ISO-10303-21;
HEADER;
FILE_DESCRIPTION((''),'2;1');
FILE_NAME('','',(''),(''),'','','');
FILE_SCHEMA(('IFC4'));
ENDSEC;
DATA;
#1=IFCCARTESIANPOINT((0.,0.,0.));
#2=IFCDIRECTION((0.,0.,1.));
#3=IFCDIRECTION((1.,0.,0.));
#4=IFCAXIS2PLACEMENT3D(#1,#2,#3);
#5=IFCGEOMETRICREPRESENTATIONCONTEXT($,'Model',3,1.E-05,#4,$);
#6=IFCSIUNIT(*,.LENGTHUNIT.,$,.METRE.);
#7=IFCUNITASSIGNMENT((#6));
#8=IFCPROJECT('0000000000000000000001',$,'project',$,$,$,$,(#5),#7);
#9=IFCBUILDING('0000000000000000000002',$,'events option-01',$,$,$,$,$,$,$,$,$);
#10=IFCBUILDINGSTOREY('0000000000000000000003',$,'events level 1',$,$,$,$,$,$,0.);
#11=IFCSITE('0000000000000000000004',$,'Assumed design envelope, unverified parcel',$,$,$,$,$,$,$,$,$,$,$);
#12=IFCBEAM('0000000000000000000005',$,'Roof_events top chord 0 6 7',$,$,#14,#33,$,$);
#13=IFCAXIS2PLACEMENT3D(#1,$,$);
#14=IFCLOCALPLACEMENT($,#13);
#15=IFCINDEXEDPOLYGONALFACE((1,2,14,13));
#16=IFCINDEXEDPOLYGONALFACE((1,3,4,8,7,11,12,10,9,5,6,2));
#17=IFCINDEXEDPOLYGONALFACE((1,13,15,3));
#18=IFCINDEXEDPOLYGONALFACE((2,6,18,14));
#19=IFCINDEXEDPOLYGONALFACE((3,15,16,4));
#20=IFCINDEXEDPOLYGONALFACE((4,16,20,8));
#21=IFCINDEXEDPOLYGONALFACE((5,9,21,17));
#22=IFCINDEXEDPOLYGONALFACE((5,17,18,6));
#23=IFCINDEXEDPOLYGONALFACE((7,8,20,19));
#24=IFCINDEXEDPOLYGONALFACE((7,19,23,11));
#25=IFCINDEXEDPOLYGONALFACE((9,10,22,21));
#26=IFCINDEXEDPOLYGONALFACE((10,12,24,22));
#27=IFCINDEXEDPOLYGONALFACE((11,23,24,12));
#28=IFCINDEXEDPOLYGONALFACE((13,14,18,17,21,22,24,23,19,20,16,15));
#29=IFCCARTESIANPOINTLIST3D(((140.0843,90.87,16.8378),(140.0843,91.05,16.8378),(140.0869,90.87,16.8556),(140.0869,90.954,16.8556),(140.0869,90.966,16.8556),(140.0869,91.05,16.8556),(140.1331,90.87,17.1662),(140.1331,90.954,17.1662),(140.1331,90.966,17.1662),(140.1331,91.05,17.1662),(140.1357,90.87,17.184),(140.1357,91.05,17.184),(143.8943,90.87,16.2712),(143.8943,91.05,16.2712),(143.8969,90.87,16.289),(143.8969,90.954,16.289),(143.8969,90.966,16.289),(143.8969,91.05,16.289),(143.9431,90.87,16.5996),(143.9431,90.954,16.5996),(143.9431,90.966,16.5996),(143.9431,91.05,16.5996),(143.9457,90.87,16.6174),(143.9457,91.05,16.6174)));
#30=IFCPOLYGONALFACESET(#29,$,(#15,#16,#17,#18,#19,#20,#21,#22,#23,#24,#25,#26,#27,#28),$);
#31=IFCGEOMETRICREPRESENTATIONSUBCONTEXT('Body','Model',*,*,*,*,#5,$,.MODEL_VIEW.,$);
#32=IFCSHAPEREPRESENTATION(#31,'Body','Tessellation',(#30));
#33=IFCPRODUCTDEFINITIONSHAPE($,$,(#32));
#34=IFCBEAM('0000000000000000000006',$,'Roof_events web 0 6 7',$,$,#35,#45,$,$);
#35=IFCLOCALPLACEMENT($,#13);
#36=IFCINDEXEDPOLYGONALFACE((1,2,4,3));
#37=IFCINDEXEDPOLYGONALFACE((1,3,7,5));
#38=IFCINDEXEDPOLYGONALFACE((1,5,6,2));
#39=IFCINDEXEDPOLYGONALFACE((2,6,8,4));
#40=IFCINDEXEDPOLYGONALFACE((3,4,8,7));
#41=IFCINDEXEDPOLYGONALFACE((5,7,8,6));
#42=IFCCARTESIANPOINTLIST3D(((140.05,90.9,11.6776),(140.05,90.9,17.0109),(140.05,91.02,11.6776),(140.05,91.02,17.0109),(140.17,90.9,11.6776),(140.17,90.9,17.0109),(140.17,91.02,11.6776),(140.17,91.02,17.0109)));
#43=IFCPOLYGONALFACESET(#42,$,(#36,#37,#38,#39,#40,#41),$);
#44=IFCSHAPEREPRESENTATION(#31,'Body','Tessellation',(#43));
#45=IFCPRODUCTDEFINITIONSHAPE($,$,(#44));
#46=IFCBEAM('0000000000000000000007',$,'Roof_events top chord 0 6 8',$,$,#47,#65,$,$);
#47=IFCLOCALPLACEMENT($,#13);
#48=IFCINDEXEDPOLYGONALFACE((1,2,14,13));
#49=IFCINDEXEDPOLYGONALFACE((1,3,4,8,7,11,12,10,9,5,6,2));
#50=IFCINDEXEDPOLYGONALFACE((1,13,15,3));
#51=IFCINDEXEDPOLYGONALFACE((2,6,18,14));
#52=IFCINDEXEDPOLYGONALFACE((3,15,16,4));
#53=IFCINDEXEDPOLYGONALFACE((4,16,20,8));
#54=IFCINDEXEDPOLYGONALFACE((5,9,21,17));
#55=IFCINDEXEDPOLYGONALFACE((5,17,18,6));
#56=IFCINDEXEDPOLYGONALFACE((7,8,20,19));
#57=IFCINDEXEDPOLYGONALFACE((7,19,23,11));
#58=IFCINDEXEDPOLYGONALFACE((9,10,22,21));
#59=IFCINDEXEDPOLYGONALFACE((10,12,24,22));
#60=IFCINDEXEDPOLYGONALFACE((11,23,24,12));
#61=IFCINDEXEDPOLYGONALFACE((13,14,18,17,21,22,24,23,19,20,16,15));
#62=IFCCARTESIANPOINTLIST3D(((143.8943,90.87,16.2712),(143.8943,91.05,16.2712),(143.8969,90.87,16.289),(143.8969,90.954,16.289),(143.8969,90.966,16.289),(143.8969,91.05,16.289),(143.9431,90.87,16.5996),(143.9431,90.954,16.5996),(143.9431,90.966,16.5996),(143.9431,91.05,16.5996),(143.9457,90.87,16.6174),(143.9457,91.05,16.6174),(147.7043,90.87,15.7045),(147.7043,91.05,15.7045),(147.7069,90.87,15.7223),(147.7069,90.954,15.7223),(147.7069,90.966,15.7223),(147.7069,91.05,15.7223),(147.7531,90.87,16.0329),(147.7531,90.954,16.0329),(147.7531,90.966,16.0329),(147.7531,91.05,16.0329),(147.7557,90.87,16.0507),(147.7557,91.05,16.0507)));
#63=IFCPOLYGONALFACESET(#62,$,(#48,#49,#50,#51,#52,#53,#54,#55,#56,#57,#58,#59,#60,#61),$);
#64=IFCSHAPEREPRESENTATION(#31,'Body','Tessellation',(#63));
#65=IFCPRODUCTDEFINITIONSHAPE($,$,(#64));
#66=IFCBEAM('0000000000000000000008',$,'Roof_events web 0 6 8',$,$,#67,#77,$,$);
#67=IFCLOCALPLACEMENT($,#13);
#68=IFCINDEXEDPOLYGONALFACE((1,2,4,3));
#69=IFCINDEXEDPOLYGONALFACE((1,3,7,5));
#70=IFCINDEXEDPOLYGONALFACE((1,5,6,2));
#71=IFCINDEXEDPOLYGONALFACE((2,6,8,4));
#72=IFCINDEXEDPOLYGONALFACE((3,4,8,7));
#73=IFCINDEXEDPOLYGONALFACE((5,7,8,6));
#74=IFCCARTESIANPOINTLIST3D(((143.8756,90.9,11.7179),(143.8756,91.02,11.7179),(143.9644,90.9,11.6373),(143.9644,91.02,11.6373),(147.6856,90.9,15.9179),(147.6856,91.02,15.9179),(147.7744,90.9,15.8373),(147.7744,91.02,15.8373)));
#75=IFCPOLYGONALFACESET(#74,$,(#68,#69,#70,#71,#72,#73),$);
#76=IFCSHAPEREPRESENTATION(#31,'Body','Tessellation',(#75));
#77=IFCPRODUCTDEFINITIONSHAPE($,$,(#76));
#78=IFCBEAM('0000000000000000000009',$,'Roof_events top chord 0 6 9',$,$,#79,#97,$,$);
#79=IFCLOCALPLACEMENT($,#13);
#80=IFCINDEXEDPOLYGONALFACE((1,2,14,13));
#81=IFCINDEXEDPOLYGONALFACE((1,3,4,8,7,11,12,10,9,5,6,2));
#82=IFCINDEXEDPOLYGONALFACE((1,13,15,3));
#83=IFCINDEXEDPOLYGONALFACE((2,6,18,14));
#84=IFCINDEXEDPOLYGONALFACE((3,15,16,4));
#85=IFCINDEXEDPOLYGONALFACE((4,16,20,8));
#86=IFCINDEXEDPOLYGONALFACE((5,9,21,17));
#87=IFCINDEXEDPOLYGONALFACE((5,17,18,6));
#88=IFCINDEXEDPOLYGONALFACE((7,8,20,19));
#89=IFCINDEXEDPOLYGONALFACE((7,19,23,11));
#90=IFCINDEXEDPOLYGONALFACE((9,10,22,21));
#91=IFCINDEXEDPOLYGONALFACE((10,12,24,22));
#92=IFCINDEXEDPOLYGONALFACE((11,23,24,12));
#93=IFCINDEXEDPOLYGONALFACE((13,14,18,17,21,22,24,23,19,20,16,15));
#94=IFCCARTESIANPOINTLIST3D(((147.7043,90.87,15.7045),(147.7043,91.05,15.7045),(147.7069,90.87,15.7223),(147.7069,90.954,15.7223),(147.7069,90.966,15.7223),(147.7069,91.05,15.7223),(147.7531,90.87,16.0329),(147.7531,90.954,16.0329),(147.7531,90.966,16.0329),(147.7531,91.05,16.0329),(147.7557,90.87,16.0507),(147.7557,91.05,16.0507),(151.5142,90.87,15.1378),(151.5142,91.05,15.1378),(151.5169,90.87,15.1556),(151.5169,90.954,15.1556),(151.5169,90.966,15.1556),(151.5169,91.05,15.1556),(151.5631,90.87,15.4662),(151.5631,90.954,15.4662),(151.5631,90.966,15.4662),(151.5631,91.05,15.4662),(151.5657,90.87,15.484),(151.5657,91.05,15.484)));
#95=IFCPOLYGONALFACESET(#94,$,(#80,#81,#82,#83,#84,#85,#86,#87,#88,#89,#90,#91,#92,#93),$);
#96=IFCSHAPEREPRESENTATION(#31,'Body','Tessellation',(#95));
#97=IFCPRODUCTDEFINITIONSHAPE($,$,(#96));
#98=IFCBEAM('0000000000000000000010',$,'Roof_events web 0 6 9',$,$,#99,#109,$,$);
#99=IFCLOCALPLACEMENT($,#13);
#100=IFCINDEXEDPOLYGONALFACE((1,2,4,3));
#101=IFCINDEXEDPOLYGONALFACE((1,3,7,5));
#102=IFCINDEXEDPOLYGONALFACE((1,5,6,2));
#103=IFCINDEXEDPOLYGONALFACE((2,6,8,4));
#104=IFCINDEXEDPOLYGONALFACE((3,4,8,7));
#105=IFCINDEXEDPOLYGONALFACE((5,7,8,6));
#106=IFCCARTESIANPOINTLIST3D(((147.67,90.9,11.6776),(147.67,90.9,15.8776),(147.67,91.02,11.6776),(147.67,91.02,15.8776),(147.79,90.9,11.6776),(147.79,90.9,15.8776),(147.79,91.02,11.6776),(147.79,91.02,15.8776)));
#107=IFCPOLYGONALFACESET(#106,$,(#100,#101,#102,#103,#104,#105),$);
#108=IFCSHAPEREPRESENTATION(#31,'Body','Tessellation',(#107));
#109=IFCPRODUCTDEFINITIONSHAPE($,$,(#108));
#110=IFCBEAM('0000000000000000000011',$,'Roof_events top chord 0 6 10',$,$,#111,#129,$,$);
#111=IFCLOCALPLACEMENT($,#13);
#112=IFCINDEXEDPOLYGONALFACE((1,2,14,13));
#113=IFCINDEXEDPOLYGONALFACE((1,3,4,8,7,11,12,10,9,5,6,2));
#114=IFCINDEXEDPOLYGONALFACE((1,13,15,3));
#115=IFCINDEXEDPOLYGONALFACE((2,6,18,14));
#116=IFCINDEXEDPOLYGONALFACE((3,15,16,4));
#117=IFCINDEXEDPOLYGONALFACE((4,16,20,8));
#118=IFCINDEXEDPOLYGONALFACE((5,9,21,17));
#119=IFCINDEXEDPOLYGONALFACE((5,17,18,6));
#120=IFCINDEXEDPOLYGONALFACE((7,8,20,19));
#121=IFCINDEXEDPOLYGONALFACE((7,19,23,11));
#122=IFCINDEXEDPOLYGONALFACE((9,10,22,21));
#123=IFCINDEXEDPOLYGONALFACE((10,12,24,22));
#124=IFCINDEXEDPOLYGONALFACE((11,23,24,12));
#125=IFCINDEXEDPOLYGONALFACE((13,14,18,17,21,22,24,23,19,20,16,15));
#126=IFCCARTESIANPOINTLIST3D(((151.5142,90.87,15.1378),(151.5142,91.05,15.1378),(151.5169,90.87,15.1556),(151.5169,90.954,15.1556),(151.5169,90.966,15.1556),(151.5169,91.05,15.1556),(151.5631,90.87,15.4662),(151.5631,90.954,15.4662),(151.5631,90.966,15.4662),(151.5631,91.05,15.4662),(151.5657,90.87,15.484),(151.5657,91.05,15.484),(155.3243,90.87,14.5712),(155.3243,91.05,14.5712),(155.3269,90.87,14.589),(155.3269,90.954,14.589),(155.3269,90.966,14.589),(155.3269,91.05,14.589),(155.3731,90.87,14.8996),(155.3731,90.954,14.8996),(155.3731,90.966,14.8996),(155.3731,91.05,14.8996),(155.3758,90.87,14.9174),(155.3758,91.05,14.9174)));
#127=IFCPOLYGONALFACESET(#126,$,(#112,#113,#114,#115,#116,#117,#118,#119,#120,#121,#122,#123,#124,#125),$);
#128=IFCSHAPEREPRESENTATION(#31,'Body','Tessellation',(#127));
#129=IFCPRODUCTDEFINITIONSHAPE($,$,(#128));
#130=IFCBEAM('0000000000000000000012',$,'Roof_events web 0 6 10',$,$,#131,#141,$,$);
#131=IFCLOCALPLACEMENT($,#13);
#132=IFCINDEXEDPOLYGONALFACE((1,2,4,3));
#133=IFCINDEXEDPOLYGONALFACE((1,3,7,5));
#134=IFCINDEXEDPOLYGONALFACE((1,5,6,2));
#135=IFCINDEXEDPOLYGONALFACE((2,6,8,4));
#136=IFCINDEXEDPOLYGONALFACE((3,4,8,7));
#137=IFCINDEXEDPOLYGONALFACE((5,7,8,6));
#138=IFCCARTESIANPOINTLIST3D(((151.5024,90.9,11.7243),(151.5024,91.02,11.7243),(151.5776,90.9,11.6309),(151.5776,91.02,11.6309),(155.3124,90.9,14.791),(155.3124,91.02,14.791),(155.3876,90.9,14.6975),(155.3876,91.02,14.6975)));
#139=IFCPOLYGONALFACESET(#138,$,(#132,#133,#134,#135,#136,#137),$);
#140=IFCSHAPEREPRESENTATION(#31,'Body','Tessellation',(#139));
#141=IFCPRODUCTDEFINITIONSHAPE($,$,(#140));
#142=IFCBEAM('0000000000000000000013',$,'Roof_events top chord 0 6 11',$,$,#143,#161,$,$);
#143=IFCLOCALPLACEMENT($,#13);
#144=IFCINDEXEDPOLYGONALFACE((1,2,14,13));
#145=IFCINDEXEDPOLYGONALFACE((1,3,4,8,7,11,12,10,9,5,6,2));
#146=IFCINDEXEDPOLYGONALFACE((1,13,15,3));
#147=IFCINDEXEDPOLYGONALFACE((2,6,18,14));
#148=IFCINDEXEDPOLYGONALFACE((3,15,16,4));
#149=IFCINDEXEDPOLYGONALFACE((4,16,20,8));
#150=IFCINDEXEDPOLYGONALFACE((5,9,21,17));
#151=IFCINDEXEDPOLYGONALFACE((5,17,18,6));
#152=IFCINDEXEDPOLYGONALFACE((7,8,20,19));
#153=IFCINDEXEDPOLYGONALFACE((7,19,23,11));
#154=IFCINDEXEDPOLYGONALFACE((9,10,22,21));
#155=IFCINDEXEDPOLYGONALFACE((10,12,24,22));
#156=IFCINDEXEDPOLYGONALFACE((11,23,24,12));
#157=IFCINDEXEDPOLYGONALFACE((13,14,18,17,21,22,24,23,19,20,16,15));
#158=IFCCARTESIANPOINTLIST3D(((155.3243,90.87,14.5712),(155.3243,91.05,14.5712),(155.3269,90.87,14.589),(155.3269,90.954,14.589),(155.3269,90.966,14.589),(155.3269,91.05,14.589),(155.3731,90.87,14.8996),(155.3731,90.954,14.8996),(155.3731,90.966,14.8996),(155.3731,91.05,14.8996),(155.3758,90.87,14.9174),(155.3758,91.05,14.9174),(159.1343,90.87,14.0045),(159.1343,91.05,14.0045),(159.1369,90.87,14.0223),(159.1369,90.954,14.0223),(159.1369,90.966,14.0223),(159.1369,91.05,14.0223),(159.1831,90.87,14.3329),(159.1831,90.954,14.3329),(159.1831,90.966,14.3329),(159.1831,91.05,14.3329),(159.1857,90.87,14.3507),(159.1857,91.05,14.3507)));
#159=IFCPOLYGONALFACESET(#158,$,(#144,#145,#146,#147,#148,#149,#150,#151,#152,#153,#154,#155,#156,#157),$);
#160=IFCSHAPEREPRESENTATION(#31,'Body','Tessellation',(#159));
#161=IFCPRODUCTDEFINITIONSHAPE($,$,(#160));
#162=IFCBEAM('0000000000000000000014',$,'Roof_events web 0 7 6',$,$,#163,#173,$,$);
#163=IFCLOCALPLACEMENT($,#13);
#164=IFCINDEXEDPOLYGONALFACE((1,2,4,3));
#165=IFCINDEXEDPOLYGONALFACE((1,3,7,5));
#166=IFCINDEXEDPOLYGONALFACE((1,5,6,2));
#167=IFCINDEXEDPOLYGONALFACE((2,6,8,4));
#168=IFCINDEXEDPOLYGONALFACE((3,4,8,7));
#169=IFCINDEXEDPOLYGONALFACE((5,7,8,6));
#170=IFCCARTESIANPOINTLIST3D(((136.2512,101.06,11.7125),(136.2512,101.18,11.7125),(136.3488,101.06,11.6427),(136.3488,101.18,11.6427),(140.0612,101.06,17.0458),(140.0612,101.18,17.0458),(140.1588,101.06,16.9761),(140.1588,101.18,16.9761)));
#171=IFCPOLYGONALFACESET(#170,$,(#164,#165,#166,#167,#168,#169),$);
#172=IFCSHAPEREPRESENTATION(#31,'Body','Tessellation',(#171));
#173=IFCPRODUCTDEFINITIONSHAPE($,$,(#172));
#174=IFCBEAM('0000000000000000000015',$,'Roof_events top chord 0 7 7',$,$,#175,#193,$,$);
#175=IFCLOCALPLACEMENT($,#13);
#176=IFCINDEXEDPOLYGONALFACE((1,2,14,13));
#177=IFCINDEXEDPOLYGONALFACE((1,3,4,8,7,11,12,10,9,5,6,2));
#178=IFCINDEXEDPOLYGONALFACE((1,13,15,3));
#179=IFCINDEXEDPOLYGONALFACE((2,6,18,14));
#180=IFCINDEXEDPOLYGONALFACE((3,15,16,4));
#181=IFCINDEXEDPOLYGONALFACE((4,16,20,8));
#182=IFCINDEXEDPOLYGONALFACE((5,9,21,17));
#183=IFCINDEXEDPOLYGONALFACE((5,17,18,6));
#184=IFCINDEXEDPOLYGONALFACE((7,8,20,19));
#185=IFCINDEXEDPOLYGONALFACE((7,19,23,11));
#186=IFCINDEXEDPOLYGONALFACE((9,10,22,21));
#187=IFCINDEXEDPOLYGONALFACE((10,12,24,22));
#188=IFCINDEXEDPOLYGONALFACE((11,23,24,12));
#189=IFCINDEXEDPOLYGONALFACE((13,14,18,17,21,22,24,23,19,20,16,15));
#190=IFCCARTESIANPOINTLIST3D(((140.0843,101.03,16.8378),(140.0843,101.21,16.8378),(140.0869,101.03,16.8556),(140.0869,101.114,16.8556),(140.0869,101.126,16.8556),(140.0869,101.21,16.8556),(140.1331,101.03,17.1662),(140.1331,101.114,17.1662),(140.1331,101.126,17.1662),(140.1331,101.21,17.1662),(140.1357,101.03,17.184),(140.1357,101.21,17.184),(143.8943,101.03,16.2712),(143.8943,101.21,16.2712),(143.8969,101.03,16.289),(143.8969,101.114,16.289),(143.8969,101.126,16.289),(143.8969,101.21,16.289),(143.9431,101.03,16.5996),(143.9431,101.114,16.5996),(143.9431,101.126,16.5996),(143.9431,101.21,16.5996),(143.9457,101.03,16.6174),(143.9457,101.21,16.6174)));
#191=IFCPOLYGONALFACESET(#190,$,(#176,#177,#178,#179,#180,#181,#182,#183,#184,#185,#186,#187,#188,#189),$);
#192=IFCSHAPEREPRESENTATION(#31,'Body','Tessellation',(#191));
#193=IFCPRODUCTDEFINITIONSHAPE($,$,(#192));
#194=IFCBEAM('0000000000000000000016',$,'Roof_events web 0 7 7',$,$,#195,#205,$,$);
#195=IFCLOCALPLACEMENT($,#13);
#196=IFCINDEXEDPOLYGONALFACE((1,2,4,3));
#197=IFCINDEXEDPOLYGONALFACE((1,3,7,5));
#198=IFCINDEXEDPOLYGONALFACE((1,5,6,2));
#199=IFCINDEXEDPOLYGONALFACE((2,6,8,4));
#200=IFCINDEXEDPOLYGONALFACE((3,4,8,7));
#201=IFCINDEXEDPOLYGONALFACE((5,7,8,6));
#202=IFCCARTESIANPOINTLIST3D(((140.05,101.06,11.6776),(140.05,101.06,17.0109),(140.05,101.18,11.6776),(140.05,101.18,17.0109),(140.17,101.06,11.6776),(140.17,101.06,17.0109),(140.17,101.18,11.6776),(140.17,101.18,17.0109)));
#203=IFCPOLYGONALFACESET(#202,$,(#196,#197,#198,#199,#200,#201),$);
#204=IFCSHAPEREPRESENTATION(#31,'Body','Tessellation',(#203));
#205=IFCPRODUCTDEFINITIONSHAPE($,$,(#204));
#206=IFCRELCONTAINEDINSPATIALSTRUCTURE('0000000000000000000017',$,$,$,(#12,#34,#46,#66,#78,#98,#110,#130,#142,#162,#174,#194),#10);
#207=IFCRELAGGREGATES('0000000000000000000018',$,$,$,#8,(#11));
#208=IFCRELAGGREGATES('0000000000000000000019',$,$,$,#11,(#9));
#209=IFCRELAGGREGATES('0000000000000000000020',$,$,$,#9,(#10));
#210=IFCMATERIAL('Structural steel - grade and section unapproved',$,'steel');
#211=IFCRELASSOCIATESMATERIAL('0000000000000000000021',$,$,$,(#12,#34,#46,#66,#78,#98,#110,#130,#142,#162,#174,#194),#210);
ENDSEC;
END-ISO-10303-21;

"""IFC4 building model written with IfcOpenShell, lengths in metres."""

from ifc_helpers import new_model, si_unit, frame, origin_with_axes, place, context, subcontext, project, spatial, rectangle, i_section, extrude, material, element, save


model = new_model("IFC4")

# Units and contexts
model_context = context("Model", 3, precision=1e-05, world=origin_with_axes())
body_context = subcontext(model_context, "Body", "Model", "MODEL_VIEW")
ifc_project = project(units=[si_unit("LENGTHUNIT", "METRE")], contexts=[model_context])

# Site, building, storey
site = spatial("IfcSite", under=ifc_project, Name="Assumed design envelope, unverified parcel")
building = spatial("IfcBuilding", under=site, Name="events option-01")
storey = spatial("IfcBuildingStorey", under=building, Name="events level 1", Elevation=0.0)

# Beams
ifc_material = material(Name="Structural steel - grade and section unapproved", Category="steel")
beam_1_placement = place(None, frame((140.11, 90.96, 17.0109), z_axis=(0.98912, 0.0, -0.147113), x_axis=(0.0, 1.0, 0.0)))
element("IfcBeam", 1, at=beam_1_placement, inside=storey, material=ifc_material, Name="Roof_events top chord 0 6 7", context=body_context, shape_type="SweptSolid", body=[
    extrude(i_section(OverallWidth=0.18, OverallDepth=0.35, WebThickness=0.012, FlangeThickness=0.018, FilletRadius=0.0), origin_with_axes(), (0.0, 0.0, 1.0), 3.8519),
])
beam_2_placement = place(None, frame((140.11, 90.96, 11.6776), z_axis=(0.0, 0.0, 1.0), x_axis=(-1.0, 0.0, 0.0)))
element("IfcBeam", 2, at=beam_2_placement, inside=storey, material=ifc_material, Name="Roof_events web 0 6 7", context=body_context, shape_type="SweptSolid", body=[
    extrude(rectangle(XDim=0.12, YDim=0.12), origin_with_axes(), (0.0, 0.0, 1.0), 5.3333),
])
beam_3_placement = place(None, frame((143.92, 90.96, 16.4443), z_axis=(0.98912, 0.0, -0.147113), x_axis=(0.0, 1.0, 0.0)))
element("IfcBeam", 3, at=beam_3_placement, inside=storey, material=ifc_material, Name="Roof_events top chord 0 6 8", context=body_context, shape_type="SweptSolid", body=[
    extrude(i_section(OverallWidth=0.18, OverallDepth=0.35, WebThickness=0.012, FlangeThickness=0.018, FilletRadius=0.0), origin_with_axes(), (0.0, 0.0, 1.0), 3.8519),
])
beam_4_placement = place(None, frame((143.92, 90.96, 11.6776), z_axis=(0.671882, 0.0, 0.740658), x_axis=(0.0, 1.0, 0.0)))
element("IfcBeam", 4, at=beam_4_placement, inside=storey, material=ifc_material, Name="Roof_events web 0 6 8", context=body_context, shape_type="SweptSolid", body=[
    extrude(rectangle(XDim=0.12, YDim=0.12), origin_with_axes(), (0.0, 0.0, 1.0), 5.6706),
])
beam_5_placement = place(None, frame((147.73, 90.96, 15.8776), z_axis=(0.98912, 0.0, -0.147113), x_axis=(0.0, 1.0, 0.0)))
element("IfcBeam", 5, at=beam_5_placement, inside=storey, material=ifc_material, Name="Roof_events top chord 0 6 9", context=body_context, shape_type="SweptSolid", body=[
    extrude(i_section(OverallWidth=0.18, OverallDepth=0.35, WebThickness=0.012, FlangeThickness=0.018, FilletRadius=0.0), origin_with_axes(), (0.0, 0.0, 1.0), 3.8519),
])
beam_6_placement = place(None, frame((147.73, 90.96, 11.6776), z_axis=(0.0, 0.0, 1.0), x_axis=(-1.0, 0.0, 0.0)))
element("IfcBeam", 6, at=beam_6_placement, inside=storey, material=ifc_material, Name="Roof_events web 0 6 9", context=body_context, shape_type="SweptSolid", body=[
    extrude(rectangle(XDim=0.12, YDim=0.12), origin_with_axes(), (0.0, 0.0, 1.0), 4.2),
])
beam_7_placement = place(None, frame((151.54, 90.96, 15.3109), z_axis=(0.98912, 0.0, -0.147113), x_axis=(0.0, 1.0, 0.0)))
element("IfcBeam", 7, at=beam_7_placement, inside=storey, material=ifc_material, Name="Roof_events top chord 0 6 10", context=body_context, shape_type="SweptSolid", body=[
    extrude(i_section(OverallWidth=0.18, OverallDepth=0.35, WebThickness=0.012, FlangeThickness=0.018, FilletRadius=0.0), origin_with_axes(), (0.0, 0.0, 1.0), 3.8519),
])
beam_8_placement = place(None, frame((151.54, 90.96, 11.6776), z_axis=(0.779005, 0.0, 0.627018), x_axis=(0.0, 1.0, 0.0)))
element("IfcBeam", 8, at=beam_8_placement, inside=storey, material=ifc_material, Name="Roof_events web 0 6 10", context=body_context, shape_type="SweptSolid", body=[
    extrude(rectangle(XDim=0.12, YDim=0.12), origin_with_axes(), (0.0, 0.0, 1.0), 4.8909),
])
beam_9_placement = place(None, frame((155.35, 90.96, 14.7443), z_axis=(0.98912, 0.0, -0.147113), x_axis=(0.0, 1.0, 0.0)))
element("IfcBeam", 9, at=beam_9_placement, inside=storey, material=ifc_material, Name="Roof_events top chord 0 6 11", context=body_context, shape_type="SweptSolid", body=[
    extrude(i_section(OverallWidth=0.18, OverallDepth=0.35, WebThickness=0.012, FlangeThickness=0.018, FilletRadius=0.0), origin_with_axes(), (0.0, 0.0, 1.0), 3.8519),
])
beam_10_placement = place(None, frame((136.3, 101.12, 11.6776), z_axis=(0.581286, 0.0, 0.813699), x_axis=(0.0, 1.0, 0.0)))
element("IfcBeam", 10, at=beam_10_placement, inside=storey, material=ifc_material, Name="Roof_events web 0 7 6", context=body_context, shape_type="SweptSolid", body=[
    extrude(rectangle(XDim=0.12, YDim=0.12), origin_with_axes(), (0.0, 0.0, 1.0), 6.5544),
])
beam_11_placement = place(None, frame((140.11, 101.12, 17.0109), z_axis=(0.98912, 0.0, -0.147113), x_axis=(0.0, 1.0, 0.0)))
element("IfcBeam", 11, at=beam_11_placement, inside=storey, material=ifc_material, Name="Roof_events top chord 0 7 7", context=body_context, shape_type="SweptSolid", body=[
    extrude(i_section(OverallWidth=0.18, OverallDepth=0.35, WebThickness=0.012, FlangeThickness=0.018, FilletRadius=0.0), origin_with_axes(), (0.0, 0.0, 1.0), 3.8519),
])
beam_12_placement = place(None, frame((140.11, 101.12, 11.6776), z_axis=(0.0, 0.0, 1.0), x_axis=(-1.0, 0.0, 0.0)))
element("IfcBeam", 12, at=beam_12_placement, inside=storey, material=ifc_material, Name="Roof_events web 0 7 7", context=body_context, shape_type="SweptSolid", body=[
    extrude(rectangle(XDim=0.12, YDim=0.12), origin_with_axes(), (0.0, 0.0, 1.0), 5.3333),
])

save(model, "model.ifc")
